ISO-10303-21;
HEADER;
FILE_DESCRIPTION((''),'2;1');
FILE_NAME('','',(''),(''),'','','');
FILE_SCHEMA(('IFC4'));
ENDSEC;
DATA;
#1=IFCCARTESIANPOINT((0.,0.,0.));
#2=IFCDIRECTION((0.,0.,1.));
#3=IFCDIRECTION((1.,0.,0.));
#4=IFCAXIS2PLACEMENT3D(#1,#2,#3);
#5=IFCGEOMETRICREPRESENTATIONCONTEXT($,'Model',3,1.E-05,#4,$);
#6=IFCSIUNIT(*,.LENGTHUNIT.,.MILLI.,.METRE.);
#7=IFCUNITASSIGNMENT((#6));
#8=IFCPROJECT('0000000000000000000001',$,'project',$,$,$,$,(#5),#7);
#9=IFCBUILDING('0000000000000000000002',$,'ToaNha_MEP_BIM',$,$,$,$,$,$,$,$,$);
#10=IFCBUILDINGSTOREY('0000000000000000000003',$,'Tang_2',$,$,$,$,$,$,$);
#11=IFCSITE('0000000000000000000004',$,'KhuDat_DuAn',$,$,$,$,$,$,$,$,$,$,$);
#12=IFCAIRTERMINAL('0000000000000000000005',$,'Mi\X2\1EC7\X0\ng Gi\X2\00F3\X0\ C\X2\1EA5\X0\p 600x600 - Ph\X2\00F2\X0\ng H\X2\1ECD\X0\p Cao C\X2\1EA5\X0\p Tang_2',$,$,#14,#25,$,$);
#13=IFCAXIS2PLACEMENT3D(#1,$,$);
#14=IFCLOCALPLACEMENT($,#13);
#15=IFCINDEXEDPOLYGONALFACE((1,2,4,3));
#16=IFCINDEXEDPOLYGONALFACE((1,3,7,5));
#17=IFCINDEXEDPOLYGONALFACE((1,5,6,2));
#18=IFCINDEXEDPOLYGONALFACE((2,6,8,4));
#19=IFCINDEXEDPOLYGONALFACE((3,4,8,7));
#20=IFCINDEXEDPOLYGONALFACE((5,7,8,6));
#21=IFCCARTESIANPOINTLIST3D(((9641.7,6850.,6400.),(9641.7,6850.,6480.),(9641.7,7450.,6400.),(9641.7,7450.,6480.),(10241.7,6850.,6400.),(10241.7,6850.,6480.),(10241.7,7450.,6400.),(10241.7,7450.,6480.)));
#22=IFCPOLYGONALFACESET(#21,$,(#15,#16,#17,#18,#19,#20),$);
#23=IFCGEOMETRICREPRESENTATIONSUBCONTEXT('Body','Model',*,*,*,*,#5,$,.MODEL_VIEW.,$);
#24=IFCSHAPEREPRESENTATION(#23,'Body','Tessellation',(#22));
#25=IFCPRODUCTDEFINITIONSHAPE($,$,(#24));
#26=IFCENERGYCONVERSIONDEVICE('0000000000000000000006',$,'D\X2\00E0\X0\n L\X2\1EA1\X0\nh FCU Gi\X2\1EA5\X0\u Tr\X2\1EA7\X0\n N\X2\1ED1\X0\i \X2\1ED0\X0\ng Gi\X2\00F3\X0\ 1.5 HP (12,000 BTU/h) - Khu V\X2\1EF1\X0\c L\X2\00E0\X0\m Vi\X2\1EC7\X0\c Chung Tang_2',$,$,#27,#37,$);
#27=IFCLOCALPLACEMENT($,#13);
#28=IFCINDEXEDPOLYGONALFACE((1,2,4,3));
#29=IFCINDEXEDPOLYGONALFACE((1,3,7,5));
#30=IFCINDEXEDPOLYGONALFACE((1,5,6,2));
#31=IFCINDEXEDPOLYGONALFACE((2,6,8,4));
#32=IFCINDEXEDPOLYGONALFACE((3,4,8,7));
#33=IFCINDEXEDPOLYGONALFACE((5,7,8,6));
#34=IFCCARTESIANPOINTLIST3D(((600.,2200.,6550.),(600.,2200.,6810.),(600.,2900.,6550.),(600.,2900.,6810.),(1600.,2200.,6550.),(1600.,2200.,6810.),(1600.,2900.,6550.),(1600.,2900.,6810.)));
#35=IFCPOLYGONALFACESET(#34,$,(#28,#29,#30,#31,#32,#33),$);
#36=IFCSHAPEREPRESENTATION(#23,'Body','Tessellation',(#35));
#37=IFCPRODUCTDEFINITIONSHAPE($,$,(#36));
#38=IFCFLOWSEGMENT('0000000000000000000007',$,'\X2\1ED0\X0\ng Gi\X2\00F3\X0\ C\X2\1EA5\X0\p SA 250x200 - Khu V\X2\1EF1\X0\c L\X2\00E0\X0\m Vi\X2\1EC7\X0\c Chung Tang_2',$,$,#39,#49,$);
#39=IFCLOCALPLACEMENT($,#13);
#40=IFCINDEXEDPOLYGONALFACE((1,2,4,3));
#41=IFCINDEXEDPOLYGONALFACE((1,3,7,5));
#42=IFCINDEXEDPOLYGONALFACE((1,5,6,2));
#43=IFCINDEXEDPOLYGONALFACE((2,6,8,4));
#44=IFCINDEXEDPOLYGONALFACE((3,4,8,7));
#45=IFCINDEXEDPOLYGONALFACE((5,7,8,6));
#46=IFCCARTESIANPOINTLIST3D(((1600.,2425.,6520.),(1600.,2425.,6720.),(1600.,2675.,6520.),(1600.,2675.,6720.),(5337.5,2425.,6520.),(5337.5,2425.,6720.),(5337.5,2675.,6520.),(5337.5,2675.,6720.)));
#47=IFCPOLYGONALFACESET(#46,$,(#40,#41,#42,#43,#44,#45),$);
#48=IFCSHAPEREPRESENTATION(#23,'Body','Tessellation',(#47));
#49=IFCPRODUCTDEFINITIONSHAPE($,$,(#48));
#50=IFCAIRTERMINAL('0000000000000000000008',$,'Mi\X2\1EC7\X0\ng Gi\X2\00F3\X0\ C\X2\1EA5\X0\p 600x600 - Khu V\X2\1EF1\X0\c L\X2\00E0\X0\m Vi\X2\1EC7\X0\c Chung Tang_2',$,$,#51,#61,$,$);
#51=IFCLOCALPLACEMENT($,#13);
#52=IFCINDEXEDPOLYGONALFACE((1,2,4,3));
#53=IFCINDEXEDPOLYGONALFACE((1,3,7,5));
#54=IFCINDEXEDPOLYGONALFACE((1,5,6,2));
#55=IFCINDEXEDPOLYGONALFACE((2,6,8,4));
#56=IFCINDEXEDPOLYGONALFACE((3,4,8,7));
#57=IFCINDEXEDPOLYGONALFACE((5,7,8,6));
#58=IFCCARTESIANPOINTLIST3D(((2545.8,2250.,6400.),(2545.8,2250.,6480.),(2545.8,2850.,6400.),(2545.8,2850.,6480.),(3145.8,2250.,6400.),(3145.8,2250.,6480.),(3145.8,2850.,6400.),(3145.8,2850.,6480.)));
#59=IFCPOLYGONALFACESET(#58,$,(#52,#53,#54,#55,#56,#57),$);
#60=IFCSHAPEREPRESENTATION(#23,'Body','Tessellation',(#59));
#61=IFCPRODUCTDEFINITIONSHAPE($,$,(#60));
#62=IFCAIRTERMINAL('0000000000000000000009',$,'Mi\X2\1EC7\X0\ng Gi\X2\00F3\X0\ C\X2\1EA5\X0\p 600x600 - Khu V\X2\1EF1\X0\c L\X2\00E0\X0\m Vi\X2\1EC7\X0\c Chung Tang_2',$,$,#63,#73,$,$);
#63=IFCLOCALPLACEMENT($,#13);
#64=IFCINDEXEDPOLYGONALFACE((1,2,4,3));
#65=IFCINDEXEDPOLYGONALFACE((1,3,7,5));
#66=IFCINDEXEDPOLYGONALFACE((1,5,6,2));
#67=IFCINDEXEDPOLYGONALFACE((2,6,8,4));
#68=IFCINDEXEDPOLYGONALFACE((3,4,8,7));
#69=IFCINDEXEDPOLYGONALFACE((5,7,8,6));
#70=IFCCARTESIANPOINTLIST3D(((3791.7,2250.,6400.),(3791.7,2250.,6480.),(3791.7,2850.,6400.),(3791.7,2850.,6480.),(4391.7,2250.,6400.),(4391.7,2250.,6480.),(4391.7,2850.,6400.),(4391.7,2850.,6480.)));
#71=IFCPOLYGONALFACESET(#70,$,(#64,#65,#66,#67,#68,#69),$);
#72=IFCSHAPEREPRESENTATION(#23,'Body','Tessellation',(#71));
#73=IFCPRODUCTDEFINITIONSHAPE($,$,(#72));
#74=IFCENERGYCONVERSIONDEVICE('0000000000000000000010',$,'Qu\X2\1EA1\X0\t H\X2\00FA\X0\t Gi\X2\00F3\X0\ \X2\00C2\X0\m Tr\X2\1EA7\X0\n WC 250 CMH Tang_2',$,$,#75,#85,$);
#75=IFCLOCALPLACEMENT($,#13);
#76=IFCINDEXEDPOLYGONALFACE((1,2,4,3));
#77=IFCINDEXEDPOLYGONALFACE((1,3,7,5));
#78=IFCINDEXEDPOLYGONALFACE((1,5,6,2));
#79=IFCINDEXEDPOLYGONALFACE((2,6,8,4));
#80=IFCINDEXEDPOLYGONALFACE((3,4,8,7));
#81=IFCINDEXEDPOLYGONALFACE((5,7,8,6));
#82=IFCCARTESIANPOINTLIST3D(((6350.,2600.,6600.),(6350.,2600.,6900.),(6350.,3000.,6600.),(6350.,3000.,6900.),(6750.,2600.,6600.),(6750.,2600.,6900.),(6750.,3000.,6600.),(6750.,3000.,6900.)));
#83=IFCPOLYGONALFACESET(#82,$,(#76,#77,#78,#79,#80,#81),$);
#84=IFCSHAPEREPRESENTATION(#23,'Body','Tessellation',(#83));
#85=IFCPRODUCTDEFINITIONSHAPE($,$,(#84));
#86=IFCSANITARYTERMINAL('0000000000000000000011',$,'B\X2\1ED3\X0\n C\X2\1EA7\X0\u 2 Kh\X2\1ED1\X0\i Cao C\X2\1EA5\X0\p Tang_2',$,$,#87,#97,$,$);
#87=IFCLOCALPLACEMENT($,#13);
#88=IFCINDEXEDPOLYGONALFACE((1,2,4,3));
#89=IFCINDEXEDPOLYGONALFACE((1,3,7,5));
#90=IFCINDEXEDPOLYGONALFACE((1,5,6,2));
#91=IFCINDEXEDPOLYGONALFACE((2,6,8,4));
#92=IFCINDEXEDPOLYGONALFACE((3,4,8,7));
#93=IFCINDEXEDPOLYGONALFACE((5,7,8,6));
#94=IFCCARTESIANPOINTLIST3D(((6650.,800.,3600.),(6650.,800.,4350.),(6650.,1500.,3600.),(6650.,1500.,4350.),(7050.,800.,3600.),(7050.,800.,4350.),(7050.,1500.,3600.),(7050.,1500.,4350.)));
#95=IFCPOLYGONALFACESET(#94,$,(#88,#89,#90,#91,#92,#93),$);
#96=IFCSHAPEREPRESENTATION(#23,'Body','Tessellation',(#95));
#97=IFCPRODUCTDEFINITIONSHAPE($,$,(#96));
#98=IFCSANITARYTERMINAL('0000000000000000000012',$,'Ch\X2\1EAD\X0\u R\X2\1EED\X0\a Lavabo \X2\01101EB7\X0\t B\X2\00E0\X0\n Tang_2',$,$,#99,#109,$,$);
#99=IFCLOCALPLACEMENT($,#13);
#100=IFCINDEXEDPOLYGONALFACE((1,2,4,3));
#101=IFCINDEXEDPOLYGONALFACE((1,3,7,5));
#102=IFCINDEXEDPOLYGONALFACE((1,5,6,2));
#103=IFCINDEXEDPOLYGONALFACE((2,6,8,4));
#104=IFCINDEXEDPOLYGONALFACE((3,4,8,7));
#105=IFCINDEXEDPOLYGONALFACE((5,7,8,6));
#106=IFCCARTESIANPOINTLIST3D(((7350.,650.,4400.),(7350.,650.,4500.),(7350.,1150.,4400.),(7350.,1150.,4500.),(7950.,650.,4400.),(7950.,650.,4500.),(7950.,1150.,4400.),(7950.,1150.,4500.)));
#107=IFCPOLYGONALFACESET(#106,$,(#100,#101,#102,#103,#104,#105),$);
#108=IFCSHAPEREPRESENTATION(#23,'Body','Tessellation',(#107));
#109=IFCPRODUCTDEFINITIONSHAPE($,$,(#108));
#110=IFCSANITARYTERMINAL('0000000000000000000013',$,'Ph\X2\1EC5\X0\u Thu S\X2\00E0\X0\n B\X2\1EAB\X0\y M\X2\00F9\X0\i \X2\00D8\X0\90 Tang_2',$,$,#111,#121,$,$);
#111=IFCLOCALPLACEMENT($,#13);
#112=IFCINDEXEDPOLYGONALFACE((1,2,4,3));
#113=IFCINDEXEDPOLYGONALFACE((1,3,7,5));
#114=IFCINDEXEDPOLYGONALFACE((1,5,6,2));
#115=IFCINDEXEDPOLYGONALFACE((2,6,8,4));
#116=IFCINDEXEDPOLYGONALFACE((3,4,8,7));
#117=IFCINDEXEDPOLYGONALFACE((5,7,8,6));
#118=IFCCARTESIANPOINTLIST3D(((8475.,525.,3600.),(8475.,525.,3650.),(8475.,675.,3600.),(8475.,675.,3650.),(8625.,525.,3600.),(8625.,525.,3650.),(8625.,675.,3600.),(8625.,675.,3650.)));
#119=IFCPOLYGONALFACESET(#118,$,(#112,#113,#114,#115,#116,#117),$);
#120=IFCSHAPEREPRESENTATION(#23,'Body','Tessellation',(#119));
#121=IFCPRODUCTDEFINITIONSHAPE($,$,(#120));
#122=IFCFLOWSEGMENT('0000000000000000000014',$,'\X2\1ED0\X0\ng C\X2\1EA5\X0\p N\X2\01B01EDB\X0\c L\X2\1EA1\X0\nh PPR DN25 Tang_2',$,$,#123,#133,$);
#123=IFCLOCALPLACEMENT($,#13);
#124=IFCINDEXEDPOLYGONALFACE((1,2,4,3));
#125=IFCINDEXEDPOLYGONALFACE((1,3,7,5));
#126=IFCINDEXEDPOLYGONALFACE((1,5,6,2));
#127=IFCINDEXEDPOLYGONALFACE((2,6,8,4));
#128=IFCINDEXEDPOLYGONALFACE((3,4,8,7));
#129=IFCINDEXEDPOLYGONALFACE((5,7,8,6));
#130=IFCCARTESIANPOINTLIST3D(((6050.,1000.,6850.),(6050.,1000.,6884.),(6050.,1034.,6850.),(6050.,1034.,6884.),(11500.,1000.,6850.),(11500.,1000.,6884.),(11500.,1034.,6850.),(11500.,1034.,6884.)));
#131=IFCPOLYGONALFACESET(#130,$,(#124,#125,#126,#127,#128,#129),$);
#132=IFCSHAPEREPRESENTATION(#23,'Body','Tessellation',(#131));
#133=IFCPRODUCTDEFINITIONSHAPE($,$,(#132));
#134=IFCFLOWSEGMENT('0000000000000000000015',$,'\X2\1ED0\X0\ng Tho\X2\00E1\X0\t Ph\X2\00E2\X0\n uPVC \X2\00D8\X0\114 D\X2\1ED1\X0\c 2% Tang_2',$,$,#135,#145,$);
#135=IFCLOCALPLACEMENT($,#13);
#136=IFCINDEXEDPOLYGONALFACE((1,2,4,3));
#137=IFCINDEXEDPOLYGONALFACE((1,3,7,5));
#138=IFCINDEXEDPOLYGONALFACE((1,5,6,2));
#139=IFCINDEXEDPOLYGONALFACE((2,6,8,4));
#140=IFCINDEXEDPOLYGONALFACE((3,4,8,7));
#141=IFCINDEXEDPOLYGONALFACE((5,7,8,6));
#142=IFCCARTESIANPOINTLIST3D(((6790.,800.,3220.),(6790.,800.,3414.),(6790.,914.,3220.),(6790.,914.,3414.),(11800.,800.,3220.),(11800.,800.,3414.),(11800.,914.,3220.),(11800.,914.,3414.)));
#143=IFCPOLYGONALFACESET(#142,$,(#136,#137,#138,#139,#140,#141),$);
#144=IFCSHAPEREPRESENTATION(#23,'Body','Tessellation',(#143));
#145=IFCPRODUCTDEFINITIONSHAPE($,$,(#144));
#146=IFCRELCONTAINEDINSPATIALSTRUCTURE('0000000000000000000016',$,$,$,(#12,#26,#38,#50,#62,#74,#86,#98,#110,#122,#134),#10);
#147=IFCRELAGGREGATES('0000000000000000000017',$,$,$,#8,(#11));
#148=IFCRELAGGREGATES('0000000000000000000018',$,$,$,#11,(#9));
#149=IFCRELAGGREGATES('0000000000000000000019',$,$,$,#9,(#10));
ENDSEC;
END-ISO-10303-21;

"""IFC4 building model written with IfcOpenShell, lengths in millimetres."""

from ifc_helpers import new_model, si_unit, frame, origin_with_axes, context, subcontext, project, spatial, polyline, outline, extrude, element, save


model = new_model("IFC4")

# Units and contexts
model_context = context("Model", 3, precision=1e-05, world=origin_with_axes())
body_context = subcontext(model_context, "Body", "Model", "MODEL_VIEW")
ifc_project = project(units=[si_unit("LENGTHUNIT", "METRE", prefix="MILLI")], contexts=[model_context])

# Site, building, storey
site = spatial("IfcSite", under=ifc_project, Name="KhuDat_DuAn")
building = spatial("IfcBuilding", under=site, Name="ToaNha_MEP_BIM")
storey = spatial("IfcBuildingStorey", under=building, Name="Tang_2")

# Air terminal
element("IfcAirTerminal", 1, inside=storey, Name="Miệng Gió Cấp 600x600 - Phòng Họp Cao Cấp Tang_2", context=body_context, shape_type="SweptSolid", body=[
    extrude(outline(polyline([(9641.7, 6850.0), (10241.7, 6850.0), (10241.7, 7450.0), (9641.7, 7450.0), (9641.7, 6850.0)])), frame((0.0, 0.0, 6400.0), z_axis=(0.0, 0.0, 1.0), x_axis=(1.0, 0.0, 0.0)), (0.0, 0.0, 1.0), 80.0),
])

# Energy conversion device
element("IfcEnergyConversionDevice", 2, inside=storey, Name="Dàn Lạnh FCU Giấu Trần Nối Ống Gió 1.5 HP (12,000 BTU/h) - Khu Vực Làm Việc Chung Tang_2", context=body_context, shape_type="SweptSolid", body=[
    extrude(outline(polyline([(600.0, 2200.0), (1600.0, 2200.0), (1600.0, 2900.0), (600.0, 2900.0), (600.0, 2200.0)])), frame((0.0, 0.0, 6550.0), z_axis=(0.0, 0.0, 1.0), x_axis=(1.0, 0.0, 0.0)), (0.0, 0.0, 1.0), 260.0),
])

# Flow segment
element("IfcFlowSegment", 3, inside=storey, Name="Ống Gió Cấp SA 250x200 - Khu Vực Làm Việc Chung Tang_2", context=body_context, shape_type="SweptSolid", body=[
    extrude(outline(polyline([(1600.0, 2425.0), (5337.5, 2425.0), (5337.5, 2675.0), (1600.0, 2675.0), (1600.0, 2425.0)])), frame((0.0, 0.0, 6520.0), z_axis=(0.0, 0.0, 1.0), x_axis=(1.0, 0.0, 0.0)), (0.0, 0.0, 1.0), 200.0),
])

# Air terminals
element("IfcAirTerminal", 4, inside=storey, Name="Miệng Gió Cấp 600x600 - Khu Vực Làm Việc Chung Tang_2", context=body_context, shape_type="SweptSolid", body=[
    extrude(outline(polyline([(2545.8, 2250.0), (3145.8, 2250.0), (3145.8, 2850.0), (2545.8, 2850.0), (2545.8, 2250.0)])), frame((0.0, 0.0, 6400.0), z_axis=(0.0, 0.0, 1.0), x_axis=(1.0, 0.0, 0.0)), (0.0, 0.0, 1.0), 80.0),
])
element("IfcAirTerminal", 5, inside=storey, Name="Miệng Gió Cấp 600x600 - Khu Vực Làm Việc Chung Tang_2", context=body_context, shape_type="SweptSolid", body=[
    extrude(outline(polyline([(3791.7, 2250.0), (4391.7, 2250.0), (4391.7, 2850.0), (3791.7, 2850.0), (3791.7, 2250.0)])), frame((0.0, 0.0, 6400.0), z_axis=(0.0, 0.0, 1.0), x_axis=(1.0, 0.0, 0.0)), (0.0, 0.0, 1.0), 80.0),
])

# Energy conversion device
element("IfcEnergyConversionDevice", 6, inside=storey, Name="Quạt Hút Gió Âm Trần WC 250 CMH Tang_2", context=body_context, shape_type="SweptSolid", body=[
    extrude(outline(polyline([(6350.0, 2600.0), (6750.0, 2600.0), (6750.0, 3000.0), (6350.0, 3000.0), (6350.0, 2600.0)])), frame((0.0, 0.0, 6600.0), z_axis=(0.0, 0.0, 1.0), x_axis=(1.0, 0.0, 0.0)), (0.0, 0.0, 1.0), 300.0),
])

# Sanitary terminals
element("IfcSanitaryTerminal", 7, inside=storey, Name="Bồn Cầu 2 Khối Cao Cấp Tang_2", context=body_context, shape_type="SweptSolid", body=[
    extrude(outline(polyline([(6650.0, 800.0), (7050.0, 800.0), (7050.0, 1500.0), (6650.0, 1500.0), (6650.0, 800.0)])), frame((0.0, 0.0, 3600.0), z_axis=(0.0, 0.0, 1.0), x_axis=(1.0, 0.0, 0.0)), (0.0, 0.0, 1.0), 750.0),
])
element("IfcSanitaryTerminal", 8, inside=storey, Name="Chậu Rửa Lavabo Đặt Bàn Tang_2", context=body_context, shape_type="SweptSolid", body=[
    extrude(outline(polyline([(7350.0, 650.0), (7950.0, 650.0), (7950.0, 1150.0), (7350.0, 1150.0), (7350.0, 650.0)])), frame((0.0, 0.0, 4400.0), z_axis=(0.0, 0.0, 1.0), x_axis=(1.0, 0.0, 0.0)), (0.0, 0.0, 1.0), 100.0),
])
element("IfcSanitaryTerminal", 9, inside=storey, Name="Phễu Thu Sàn Bẫy Mùi Ø90 Tang_2", context=body_context, shape_type="SweptSolid", body=[
    extrude(outline(polyline([(8475.0, 525.0), (8625.0, 525.0), (8625.0, 675.0), (8475.0, 675.0), (8475.0, 525.0)])), frame((0.0, 0.0, 3600.0), z_axis=(0.0, 0.0, 1.0), x_axis=(1.0, 0.0, 0.0)), (0.0, 0.0, 1.0), 50.0),
])

# Flow segments
element("IfcFlowSegment", 10, inside=storey, Name="Ống Cấp Nước Lạnh PPR DN25 Tang_2", context=body_context, shape_type="SweptSolid", body=[
    extrude(outline(polyline([(6050.0, 1000.0), (11500.0, 1000.0), (11500.0, 1034.0), (6050.0, 1034.0), (6050.0, 1000.0)])), frame((0.0, 0.0, 6850.0), z_axis=(0.0, 0.0, 1.0), x_axis=(1.0, 0.0, 0.0)), (0.0, 0.0, 1.0), 34.0),
])
element("IfcFlowSegment", 11, inside=storey, Name="Ống Thoát Phân uPVC Ø114 Dốc 2% Tang_2", context=body_context, shape_type="SweptSolid", body=[
    extrude(outline(polyline([(6790.0, 800.0), (11800.0, 800.0), (11800.0, 914.0), (6790.0, 914.0), (6790.0, 800.0)])), frame((0.0, 0.0, 3220.0), z_axis=(0.0, 0.0, 1.0), x_axis=(1.0, 0.0, 0.0)), (0.0, 0.0, 1.0), 194.0),
])

save(model, "model.ifc")
